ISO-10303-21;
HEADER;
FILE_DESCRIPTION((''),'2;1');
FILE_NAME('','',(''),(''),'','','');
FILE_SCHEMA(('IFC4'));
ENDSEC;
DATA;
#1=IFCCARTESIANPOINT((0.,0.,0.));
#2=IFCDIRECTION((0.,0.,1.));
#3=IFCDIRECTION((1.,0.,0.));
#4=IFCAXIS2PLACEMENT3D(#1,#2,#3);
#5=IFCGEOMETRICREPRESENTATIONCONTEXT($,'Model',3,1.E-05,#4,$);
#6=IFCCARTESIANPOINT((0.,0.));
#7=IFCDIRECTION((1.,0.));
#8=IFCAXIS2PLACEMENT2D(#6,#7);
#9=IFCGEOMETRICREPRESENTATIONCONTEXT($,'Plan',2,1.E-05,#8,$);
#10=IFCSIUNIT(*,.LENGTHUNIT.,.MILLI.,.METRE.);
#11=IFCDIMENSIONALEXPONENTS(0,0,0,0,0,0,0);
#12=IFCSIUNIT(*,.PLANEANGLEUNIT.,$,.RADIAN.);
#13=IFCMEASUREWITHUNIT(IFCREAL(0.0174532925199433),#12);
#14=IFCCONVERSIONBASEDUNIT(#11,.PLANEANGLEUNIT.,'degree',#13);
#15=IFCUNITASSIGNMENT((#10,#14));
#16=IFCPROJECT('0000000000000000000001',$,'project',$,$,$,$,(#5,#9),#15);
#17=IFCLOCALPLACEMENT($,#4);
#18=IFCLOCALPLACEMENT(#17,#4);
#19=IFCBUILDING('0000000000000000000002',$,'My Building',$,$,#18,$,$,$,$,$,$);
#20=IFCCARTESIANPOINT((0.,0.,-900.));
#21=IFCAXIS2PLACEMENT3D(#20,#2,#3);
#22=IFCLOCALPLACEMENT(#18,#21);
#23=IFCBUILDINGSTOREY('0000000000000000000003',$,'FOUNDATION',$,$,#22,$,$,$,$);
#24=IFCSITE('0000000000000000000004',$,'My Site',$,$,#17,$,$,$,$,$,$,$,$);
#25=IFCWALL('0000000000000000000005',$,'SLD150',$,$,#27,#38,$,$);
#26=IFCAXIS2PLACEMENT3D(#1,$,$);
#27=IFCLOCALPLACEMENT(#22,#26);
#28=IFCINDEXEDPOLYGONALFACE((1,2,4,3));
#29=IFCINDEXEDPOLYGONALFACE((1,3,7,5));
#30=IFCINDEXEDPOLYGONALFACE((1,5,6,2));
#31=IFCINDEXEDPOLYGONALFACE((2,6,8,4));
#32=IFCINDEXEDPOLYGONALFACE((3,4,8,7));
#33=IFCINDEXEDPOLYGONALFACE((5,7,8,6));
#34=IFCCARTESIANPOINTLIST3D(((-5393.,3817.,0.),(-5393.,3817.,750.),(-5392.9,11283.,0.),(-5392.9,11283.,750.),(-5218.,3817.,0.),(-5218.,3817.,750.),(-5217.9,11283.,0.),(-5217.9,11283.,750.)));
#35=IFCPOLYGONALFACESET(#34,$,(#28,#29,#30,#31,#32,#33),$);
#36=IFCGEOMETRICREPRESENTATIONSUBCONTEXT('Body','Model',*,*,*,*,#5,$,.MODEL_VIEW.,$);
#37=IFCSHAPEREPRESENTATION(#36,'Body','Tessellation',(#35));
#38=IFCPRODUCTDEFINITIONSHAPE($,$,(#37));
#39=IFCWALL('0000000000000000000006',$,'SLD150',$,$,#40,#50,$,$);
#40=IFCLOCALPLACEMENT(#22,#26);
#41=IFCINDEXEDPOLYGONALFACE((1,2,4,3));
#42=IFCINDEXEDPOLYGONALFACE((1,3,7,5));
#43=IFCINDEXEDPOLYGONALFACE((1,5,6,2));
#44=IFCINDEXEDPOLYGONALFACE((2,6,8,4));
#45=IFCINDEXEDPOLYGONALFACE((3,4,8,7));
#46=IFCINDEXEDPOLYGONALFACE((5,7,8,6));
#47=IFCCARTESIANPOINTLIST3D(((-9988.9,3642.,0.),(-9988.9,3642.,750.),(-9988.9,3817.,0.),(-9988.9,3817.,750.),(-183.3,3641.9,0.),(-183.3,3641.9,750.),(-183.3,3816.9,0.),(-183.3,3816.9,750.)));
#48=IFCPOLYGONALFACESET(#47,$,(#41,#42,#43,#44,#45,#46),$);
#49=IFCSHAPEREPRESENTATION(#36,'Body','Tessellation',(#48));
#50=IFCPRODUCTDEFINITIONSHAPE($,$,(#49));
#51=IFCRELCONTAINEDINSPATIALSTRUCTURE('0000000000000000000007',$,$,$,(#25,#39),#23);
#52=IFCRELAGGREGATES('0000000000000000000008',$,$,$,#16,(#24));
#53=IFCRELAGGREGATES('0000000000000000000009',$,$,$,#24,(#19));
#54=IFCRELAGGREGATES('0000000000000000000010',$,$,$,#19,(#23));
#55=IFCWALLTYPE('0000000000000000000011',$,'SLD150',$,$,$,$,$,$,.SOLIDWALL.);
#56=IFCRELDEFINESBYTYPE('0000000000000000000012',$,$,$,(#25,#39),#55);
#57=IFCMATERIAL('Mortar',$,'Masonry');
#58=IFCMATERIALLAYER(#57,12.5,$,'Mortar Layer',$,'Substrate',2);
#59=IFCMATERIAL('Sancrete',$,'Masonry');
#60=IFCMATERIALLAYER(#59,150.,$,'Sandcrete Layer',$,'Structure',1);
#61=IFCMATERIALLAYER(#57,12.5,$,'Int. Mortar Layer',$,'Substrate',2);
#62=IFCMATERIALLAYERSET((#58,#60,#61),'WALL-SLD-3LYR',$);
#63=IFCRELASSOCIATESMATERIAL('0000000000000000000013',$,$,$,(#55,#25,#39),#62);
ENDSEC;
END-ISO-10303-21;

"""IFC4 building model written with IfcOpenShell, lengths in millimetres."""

from ifc_helpers import new_model, entity, si_unit, converted_unit, frame, origin_with_axes, origin_2d_with_axis, place, context, subcontext, project, spatial, indexed_curve, outline, extrude, material, layer, layer_set, layer_usage, type_object, element, save


model = new_model("IFC4")

# Units and contexts
model_context = context("Model", 3, precision=1e-05, world=origin_with_axes())
plan_context = context("Plan", 2, precision=1e-05, world=origin_2d_with_axis())
body_context = subcontext(model_context, "Body", "Model", "MODEL_VIEW")
ifc_project = project(units=[si_unit("LENGTHUNIT", "METRE", prefix="MILLI"), converted_unit("PLANEANGLEUNIT", "degree", entity("IfcReal", 0.0174532925199433), si_unit("PLANEANGLEUNIT", "RADIAN"), dimensions=[0, 0, 0, 0, 0, 0, 0])], contexts=[model_context, plan_context])

# Site, building, storey
site_placement = place(None, origin_with_axes())
site = spatial("IfcSite", under=ifc_project, at=site_placement, Name="My Site")
building_placement = place(site_placement, origin_with_axes())
building = spatial("IfcBuilding", under=site, at=building_placement, Name="My Building")
storey_placement = place(building_placement, frame((0.0, 0.0, -900.0), z_axis=(0.0, 0.0, 1.0), x_axis=(1.0, 0.0, 0.0)))
storey = spatial("IfcBuildingStorey", under=building, at=storey_placement, Name="FOUNDATION")

# Walls
ifc_material_1 = material(Name="Mortar", Category="Masonry")
ifc_layer_1 = layer(ifc_material_1, 12.5, Name="Mortar Layer", Category="Substrate", Priority=2)
ifc_material_2 = material(Name="Sancrete", Category="Masonry")
ifc_layer_2 = layer(ifc_material_2, 150.0, Name="Sandcrete Layer", Category="Structure", Priority=1)
ifc_layer_3 = layer(ifc_material_1, 12.5, Name="Int. Mortar Layer", Category="Substrate", Priority=2)
ifc_layer_set_1 = layer_set([ifc_layer_1, ifc_layer_2, ifc_layer_3], Name="WALL-SLD-3LYR")
wall_type = type_object("IfcWallType", Name="SLD150", PredefinedType="SOLIDWALL", material=ifc_layer_set_1)
ifc_layer_usage_1 = layer_usage(ifc_layer_set_1, "AXIS2", "POSITIVE", 0.0)
wall_1_placement = place(storey_placement, frame((-5218.0, 3817.0, 0.0), z_axis=(0.0, 0.0, 1.0), x_axis=(0.0, 1.0, 0.0)))
element("IfcWall", 1, at=wall_1_placement, inside=storey, type_object=wall_type, material=ifc_layer_usage_1, Name="SLD150", context=body_context, shape_type="SweptSolid", body=[
    extrude(outline(indexed_curve([(0.0, 0.0), (0.0, 175.0), (7466.0, 175.0), (7466.0, 0.0), (0.0, 0.0)], self_intersect=False)), origin_with_axes(), (0.0, 0.0, 1.0), 750.0),
])
ifc_layer_usage_2 = layer_usage(ifc_layer_set_1, "AXIS2", "POSITIVE", 0.0)
wall_2_placement = place(storey_placement, frame((-9988.9, 3642.0, 0.0), z_axis=(0.0, 0.0, 1.0), x_axis=(1.0, 0.0, 0.0)))
element("IfcWall", 2, at=wall_2_placement, inside=storey, type_object=wall_type, material=ifc_layer_usage_2, Name="SLD150", context=body_context, shape_type="SweptSolid", body=[
    extrude(outline(indexed_curve([(0.0, 0.0), (0.0, 175.0), (9805.7, 175.0), (9805.7, 0.0), (0.0, 0.0)], self_intersect=False)), origin_with_axes(), (0.0, 0.0, 1.0), 750.0),
])

save(model, "model.ifc")
